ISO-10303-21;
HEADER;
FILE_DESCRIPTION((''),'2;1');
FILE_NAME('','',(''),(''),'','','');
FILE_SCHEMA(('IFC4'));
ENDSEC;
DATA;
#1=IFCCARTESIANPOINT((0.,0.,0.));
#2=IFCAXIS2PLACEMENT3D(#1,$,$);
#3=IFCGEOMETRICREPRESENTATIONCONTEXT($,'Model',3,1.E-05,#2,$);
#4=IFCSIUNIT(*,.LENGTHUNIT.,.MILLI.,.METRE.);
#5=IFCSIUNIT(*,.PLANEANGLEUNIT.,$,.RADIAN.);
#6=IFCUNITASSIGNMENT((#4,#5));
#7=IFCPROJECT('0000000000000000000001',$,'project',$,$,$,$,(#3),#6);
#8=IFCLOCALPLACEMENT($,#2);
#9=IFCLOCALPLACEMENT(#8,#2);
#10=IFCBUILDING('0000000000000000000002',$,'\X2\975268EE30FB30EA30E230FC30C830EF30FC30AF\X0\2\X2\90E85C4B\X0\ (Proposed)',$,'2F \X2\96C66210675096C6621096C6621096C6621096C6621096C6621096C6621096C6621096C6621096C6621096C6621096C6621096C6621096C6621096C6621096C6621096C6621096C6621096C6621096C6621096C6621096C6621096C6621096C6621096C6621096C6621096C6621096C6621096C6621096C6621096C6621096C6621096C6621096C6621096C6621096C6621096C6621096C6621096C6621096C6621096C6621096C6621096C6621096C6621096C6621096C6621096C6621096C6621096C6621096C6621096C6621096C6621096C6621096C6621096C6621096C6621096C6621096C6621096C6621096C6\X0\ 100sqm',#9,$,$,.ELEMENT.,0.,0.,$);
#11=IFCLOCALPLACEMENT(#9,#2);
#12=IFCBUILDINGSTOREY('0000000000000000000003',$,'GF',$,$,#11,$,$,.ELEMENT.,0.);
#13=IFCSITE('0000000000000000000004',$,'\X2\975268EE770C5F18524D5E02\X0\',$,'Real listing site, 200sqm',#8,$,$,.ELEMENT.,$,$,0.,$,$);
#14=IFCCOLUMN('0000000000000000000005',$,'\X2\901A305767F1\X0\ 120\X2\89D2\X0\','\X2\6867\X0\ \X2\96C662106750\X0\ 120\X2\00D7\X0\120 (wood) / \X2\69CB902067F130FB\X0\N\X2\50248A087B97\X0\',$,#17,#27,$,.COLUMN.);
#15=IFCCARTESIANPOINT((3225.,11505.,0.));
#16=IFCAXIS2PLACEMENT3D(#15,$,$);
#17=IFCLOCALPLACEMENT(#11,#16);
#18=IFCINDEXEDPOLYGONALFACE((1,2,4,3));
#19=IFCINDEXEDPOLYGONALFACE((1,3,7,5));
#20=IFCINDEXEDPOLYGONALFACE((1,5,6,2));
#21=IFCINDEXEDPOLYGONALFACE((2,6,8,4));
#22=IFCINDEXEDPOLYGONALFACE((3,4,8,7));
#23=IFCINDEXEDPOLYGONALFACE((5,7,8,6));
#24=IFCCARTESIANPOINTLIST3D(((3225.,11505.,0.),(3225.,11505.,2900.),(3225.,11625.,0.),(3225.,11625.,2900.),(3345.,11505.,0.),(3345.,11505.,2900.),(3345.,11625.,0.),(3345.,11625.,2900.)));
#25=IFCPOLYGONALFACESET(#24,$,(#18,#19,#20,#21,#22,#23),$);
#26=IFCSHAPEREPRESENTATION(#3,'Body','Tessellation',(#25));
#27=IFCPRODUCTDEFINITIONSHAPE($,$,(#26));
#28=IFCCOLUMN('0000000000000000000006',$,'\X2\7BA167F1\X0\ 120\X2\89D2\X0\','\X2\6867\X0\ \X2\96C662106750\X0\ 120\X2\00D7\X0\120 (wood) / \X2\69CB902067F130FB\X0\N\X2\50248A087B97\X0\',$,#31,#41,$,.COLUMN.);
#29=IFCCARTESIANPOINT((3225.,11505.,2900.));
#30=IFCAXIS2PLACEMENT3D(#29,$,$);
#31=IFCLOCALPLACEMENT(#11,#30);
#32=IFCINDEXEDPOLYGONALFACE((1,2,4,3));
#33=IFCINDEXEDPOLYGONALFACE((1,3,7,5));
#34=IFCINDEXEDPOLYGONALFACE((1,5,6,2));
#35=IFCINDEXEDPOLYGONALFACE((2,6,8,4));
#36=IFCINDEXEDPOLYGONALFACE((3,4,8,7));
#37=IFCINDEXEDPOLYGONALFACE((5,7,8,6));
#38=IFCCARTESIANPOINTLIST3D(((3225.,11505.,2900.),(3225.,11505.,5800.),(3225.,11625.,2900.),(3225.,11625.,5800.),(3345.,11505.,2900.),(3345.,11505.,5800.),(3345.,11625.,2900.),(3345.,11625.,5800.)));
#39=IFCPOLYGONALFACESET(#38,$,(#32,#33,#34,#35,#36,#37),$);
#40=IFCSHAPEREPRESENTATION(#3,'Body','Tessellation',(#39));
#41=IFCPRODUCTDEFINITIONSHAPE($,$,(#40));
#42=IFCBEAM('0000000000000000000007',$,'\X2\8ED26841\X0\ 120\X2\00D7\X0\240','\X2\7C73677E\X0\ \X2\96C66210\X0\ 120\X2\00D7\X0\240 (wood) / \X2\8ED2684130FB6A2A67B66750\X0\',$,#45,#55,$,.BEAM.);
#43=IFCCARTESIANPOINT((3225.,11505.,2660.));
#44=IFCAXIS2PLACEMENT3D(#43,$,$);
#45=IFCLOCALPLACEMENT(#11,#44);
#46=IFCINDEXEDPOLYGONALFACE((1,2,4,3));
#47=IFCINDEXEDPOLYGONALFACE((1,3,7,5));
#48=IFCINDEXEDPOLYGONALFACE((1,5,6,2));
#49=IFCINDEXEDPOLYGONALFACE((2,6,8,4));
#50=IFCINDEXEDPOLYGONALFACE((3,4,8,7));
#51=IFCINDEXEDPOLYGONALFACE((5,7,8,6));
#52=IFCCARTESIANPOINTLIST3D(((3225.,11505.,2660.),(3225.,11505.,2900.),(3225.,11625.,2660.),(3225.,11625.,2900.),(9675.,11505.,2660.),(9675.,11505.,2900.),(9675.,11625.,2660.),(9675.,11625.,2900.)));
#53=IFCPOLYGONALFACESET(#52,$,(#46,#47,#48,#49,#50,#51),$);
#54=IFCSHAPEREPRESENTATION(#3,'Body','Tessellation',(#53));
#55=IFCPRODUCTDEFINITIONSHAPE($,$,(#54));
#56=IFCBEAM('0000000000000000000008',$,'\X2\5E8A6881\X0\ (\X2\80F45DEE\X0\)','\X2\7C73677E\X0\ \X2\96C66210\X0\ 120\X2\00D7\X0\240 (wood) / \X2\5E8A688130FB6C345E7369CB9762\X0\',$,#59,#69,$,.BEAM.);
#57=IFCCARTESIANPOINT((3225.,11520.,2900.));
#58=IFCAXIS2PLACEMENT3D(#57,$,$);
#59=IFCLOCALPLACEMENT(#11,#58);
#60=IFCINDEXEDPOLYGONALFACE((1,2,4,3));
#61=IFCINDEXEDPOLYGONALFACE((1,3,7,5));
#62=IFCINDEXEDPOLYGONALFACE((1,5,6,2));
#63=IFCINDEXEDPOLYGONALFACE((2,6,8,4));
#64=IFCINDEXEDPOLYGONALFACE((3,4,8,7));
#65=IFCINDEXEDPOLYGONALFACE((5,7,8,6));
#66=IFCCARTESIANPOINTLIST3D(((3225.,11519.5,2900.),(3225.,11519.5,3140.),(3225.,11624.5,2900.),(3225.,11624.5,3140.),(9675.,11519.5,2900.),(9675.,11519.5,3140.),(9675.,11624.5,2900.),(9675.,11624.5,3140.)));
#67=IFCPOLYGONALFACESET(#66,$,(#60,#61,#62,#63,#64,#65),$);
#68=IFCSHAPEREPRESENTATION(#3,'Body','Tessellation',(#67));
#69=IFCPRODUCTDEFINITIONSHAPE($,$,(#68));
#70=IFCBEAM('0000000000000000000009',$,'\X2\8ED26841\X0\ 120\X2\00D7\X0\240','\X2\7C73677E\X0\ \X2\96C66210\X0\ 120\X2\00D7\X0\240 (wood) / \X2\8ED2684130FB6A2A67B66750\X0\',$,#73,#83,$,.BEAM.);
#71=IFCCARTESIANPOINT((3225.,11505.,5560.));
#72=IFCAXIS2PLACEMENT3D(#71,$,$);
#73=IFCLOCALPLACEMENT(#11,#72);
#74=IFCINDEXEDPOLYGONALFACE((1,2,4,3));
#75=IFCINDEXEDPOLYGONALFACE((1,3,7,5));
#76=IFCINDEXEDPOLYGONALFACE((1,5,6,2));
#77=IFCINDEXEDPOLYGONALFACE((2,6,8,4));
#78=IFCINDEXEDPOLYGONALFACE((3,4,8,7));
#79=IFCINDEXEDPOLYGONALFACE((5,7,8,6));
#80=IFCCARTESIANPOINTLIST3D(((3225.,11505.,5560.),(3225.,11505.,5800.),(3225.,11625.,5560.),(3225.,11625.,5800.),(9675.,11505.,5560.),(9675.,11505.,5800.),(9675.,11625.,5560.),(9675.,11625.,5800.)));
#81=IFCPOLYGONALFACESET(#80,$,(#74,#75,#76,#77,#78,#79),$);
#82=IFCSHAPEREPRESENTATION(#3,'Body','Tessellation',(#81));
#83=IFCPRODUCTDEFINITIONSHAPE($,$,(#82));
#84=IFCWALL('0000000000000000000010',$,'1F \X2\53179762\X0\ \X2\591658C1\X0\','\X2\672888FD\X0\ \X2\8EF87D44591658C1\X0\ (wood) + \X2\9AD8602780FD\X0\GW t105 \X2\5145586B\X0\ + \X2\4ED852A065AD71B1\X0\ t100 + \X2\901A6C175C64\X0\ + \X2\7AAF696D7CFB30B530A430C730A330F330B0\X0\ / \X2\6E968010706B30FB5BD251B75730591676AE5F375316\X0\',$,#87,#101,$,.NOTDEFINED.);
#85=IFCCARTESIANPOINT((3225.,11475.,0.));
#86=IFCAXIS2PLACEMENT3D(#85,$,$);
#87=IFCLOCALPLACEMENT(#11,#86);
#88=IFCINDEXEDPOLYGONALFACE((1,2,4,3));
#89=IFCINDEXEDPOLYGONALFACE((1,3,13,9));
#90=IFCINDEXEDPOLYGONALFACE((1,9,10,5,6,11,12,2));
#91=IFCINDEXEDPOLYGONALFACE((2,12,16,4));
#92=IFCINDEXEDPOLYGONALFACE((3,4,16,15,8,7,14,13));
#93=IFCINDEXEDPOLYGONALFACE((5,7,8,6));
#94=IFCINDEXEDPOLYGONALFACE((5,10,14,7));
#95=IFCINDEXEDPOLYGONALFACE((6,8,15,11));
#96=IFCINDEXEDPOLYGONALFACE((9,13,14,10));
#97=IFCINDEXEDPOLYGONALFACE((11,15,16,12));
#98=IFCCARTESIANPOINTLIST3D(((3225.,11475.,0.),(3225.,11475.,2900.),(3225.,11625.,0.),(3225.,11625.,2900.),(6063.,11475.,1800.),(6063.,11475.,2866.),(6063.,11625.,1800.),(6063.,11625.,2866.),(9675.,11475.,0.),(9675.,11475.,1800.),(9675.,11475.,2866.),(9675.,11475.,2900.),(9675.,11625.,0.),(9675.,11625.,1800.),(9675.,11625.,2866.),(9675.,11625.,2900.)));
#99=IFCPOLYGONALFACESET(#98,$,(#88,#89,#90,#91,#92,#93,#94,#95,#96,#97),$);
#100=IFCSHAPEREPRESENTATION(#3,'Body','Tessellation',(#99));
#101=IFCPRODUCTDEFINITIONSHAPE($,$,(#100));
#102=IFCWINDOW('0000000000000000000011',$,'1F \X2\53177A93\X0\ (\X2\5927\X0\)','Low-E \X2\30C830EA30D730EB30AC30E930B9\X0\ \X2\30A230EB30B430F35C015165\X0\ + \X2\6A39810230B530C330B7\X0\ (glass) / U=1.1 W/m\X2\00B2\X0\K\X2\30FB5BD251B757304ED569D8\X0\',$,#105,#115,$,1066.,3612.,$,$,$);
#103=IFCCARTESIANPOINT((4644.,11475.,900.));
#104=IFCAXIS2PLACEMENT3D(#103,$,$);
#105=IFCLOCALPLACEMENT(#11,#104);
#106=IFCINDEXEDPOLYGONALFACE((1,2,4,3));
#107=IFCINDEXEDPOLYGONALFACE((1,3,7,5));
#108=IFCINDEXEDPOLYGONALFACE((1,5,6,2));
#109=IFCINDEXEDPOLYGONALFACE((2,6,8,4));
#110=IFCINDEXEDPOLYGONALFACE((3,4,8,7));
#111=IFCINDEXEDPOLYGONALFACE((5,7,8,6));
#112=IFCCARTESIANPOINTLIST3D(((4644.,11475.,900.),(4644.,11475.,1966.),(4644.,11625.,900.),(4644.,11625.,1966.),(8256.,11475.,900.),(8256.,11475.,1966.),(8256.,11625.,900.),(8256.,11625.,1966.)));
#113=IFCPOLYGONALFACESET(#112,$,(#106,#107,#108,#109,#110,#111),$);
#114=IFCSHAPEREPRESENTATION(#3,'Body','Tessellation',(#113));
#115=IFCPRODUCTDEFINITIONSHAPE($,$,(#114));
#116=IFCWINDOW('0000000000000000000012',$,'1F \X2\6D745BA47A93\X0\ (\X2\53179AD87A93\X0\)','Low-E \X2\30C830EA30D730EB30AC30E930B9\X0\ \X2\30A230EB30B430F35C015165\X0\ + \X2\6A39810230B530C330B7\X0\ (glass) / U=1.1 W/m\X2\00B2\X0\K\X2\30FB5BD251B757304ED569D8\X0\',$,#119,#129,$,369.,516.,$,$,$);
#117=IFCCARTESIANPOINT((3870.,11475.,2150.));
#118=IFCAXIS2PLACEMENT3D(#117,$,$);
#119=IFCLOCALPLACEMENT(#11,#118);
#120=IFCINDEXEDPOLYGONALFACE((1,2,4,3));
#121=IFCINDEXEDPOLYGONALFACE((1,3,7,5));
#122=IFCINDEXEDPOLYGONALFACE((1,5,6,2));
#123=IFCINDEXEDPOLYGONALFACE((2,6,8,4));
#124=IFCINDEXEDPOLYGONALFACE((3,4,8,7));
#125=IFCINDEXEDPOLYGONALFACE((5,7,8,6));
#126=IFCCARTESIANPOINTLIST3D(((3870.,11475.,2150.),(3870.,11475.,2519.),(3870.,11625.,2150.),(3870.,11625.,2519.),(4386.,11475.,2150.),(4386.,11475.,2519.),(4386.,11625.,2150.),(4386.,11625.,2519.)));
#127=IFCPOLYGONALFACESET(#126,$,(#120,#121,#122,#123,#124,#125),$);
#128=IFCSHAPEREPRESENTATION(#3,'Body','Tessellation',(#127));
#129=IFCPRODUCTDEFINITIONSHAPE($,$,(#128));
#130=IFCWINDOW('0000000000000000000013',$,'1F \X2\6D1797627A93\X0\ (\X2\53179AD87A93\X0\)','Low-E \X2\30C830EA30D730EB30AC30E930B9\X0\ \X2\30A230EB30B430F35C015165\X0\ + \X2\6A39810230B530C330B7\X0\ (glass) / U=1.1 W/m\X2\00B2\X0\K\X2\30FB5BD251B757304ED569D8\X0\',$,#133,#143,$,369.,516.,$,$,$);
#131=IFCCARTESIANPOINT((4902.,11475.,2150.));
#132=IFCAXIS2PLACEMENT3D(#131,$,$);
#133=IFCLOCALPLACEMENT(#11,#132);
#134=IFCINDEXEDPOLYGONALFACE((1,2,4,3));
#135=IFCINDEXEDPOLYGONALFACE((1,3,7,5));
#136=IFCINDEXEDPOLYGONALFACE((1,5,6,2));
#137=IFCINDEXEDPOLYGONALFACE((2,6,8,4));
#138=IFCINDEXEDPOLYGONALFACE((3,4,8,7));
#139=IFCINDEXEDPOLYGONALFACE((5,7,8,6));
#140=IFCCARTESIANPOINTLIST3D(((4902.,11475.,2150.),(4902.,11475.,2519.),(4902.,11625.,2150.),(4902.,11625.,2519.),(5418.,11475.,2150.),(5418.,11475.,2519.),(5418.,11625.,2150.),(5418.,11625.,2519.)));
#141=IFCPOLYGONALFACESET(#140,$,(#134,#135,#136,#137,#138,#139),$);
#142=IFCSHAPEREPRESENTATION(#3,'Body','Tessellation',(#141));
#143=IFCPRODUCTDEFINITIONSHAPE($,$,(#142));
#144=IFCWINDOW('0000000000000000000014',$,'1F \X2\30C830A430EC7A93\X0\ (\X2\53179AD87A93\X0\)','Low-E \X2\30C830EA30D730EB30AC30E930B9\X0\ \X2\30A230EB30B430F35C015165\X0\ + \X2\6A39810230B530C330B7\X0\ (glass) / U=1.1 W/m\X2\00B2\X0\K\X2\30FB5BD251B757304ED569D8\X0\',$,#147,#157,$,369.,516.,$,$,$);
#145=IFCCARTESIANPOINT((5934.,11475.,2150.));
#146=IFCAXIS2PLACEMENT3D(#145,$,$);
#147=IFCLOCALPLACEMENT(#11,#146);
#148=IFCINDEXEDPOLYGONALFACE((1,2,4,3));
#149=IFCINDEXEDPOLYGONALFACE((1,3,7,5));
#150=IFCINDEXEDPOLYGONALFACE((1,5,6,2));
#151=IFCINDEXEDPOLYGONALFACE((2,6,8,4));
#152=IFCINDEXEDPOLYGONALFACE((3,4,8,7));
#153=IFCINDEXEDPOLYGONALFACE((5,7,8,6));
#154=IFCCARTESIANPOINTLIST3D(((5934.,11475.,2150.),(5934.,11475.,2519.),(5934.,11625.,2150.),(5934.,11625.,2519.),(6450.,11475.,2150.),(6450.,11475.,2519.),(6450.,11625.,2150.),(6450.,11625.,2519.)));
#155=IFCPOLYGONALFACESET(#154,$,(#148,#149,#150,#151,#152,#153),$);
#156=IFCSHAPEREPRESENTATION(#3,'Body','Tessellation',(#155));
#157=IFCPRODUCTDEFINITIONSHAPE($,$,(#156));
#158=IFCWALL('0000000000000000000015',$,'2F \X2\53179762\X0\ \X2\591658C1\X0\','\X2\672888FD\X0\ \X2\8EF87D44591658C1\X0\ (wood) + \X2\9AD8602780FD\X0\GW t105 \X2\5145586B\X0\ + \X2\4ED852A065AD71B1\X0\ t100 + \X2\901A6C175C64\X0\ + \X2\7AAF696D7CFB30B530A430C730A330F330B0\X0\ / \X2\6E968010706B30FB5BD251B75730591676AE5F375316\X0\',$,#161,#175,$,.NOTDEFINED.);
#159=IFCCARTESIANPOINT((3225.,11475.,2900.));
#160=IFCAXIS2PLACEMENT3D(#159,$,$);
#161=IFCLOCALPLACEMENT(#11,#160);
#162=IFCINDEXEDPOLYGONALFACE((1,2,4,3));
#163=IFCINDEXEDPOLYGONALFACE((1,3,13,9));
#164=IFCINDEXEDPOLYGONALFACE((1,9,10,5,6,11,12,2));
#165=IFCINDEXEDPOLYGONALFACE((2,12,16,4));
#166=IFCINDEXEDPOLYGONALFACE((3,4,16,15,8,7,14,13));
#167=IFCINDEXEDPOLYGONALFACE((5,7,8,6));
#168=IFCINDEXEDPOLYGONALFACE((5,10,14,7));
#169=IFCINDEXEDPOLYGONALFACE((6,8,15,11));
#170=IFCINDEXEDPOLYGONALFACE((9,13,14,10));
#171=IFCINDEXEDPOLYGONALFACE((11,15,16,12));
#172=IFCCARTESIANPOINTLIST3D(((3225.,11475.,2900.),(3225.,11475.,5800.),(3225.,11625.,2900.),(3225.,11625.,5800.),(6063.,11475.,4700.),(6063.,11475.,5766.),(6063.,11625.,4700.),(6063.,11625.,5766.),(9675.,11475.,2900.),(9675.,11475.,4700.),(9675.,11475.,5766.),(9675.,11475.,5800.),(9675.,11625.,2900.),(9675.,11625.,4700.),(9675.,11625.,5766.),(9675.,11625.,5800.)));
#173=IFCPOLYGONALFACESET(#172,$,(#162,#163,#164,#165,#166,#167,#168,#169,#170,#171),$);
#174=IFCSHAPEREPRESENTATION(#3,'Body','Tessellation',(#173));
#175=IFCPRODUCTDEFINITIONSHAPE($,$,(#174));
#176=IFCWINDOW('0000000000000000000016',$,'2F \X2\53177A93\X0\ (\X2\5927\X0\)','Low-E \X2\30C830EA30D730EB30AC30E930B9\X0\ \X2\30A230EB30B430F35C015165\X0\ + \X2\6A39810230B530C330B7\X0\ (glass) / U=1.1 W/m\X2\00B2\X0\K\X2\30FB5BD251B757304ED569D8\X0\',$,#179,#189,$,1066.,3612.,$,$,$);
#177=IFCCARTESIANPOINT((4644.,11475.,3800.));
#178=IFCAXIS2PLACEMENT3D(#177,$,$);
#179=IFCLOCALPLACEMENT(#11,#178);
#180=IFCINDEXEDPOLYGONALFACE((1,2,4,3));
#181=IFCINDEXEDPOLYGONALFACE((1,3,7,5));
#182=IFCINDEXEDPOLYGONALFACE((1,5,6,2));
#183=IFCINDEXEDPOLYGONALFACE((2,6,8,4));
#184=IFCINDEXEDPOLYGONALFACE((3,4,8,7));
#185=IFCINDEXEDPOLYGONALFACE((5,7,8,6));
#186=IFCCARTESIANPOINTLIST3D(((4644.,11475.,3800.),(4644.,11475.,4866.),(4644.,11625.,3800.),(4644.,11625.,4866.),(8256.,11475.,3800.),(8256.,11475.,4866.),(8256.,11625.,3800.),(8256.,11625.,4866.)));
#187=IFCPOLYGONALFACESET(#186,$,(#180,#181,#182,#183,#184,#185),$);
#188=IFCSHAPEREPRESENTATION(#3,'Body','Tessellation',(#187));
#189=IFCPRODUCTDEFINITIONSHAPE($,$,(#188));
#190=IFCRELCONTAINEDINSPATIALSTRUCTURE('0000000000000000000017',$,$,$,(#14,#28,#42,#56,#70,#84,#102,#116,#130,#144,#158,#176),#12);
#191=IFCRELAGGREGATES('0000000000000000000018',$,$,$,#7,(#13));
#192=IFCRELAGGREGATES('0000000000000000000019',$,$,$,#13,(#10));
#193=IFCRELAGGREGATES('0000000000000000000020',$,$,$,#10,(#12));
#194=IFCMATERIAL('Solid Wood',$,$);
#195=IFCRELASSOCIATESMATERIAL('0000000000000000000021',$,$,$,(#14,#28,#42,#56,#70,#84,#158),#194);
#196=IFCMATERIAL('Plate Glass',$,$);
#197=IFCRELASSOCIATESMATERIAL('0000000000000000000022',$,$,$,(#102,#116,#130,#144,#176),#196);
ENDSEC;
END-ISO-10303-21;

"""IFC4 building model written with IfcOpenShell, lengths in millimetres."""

from ifc_helpers import new_model, si_unit, frame, frame_2d, origin, place, context, project, spatial, rectangle, extrude, material, element, fill, save


model = new_model("IFC4")

# Units and contexts
model_context = context("Model", 3, precision=1e-05, world=origin())
ifc_project = project(units=[si_unit("LENGTHUNIT", "METRE", prefix="MILLI"), si_unit("PLANEANGLEUNIT", "RADIAN")], contexts=[model_context])

# Site, building, storey
site_placement = place(None, origin())
site = spatial("IfcSite", under=ifc_project, at=site_placement, Name="青森県弘前市", ObjectType="Real listing site, 200sqm", CompositionType="ELEMENT", RefElevation=0.0)
building_placement = place(site_placement, origin())
building = spatial("IfcBuilding", under=site, at=building_placement, Name="青森・リモートワーク2部屋 (Proposed)", ObjectType="2F 集成材集成集成集成集成集成集成集成集成集成集成集成集成集成集成集成集成集成集成集成集成集成集成集成集成集成集成集成集成集成集成集成集成集成集成集成集成集成集成集成集成集成集成集成集成集成集成集成集成集成集成集成集成集成集成集成集成集成集成集 100sqm", CompositionType="ELEMENT", ElevationOfRefHeight=0.0, ElevationOfTerrain=0.0)
storey_placement = place(building_placement, origin())
storey = spatial("IfcBuildingStorey", under=building, at=storey_placement, Name="GF", CompositionType="ELEMENT", Elevation=0.0)

# Columns
ifc_material_1 = material(Name="Solid Wood")
column_1_placement = place(storey_placement, frame((3225.0, 11505.0, 0.0)))
element("IfcColumn", 1, at=column_1_placement, inside=storey, material=ifc_material_1, Name="通し柱 120角", Description="桧 集成材 120×120 (wood) / 構造柱・N値計算", PredefinedType="COLUMN", context=model_context, shape_type="SweptSolid", body=[
    extrude(rectangle(XDim=120.0, YDim=120.0, at=frame_2d((60.0, 60.0))), frame((3225.0, 11505.0, 0.0)), (0.0, 0.0, 1.0), 2900.0),
])
column_2_placement = place(storey_placement, frame((3225.0, 11505.0, 2900.0)))
element("IfcColumn", 2, at=column_2_placement, inside=storey, material=ifc_material_1, Name="管柱 120角", Description="桧 集成材 120×120 (wood) / 構造柱・N値計算", PredefinedType="COLUMN", context=model_context, shape_type="SweptSolid", body=[
    extrude(rectangle(XDim=120.0, YDim=120.0, at=frame_2d((60.0, 60.0))), frame((3225.0, 11505.0, 2900.0)), (0.0, 0.0, 1.0), 2900.0),
])

# Beams
beam_1_placement = place(storey_placement, frame((3225.0, 11505.0, 2660.0)))
element("IfcBeam", 3, at=beam_1_placement, inside=storey, material=ifc_material_1, Name="軒桁 120×240", Description="米松 集成 120×240 (wood) / 軒桁・横架材", PredefinedType="BEAM", context=model_context, shape_type="SweptSolid", body=[
    extrude(rectangle(XDim=6450.0, YDim=120.0, at=frame_2d((3225.0, 60.0))), frame((3225.0, 11505.0, 2660.0)), (0.0, 0.0, 1.0), 240.0),
])
beam_2_placement = place(storey_placement, frame((3225.0, 11520.0, 2900.0)))
element("IfcBeam", 4, at=beam_2_placement, inside=storey, material=ifc_material_1, Name="床梁 (胴差)", Description="米松 集成 120×240 (wood) / 床梁・水平構面", PredefinedType="BEAM", context=model_context, shape_type="SweptSolid", body=[
    extrude(rectangle(XDim=6450.0, YDim=105.0, at=frame_2d((3225.0, 52.0))), frame((3225.0, 11520.0, 2900.0)), (0.0, 0.0, 1.0), 240.0),
])
beam_3_placement = place(storey_placement, frame((3225.0, 11505.0, 5560.0)))
element("IfcBeam", 5, at=beam_3_placement, inside=storey, material=ifc_material_1, Name="軒桁 120×240", Description="米松 集成 120×240 (wood) / 軒桁・横架材", PredefinedType="BEAM", context=model_context, shape_type="SweptSolid", body=[
    extrude(rectangle(XDim=6450.0, YDim=120.0, at=frame_2d((3225.0, 60.0))), frame((3225.0, 11505.0, 5560.0)), (0.0, 0.0, 1.0), 240.0),
])

# Wall, openings, windows
wall_1_placement = place(storey_placement, frame((3225.0, 11475.0, 0.0)))
wall_1 = element("IfcWall", 6, at=wall_1_placement, inside=storey, material=ifc_material_1, Name="1F 北面 外壁", Description="木製 軸組外壁 (wood) + 高性能GW t105 充填 + 付加断熱 t100 + 通気層 + 窯業系サイディング / 準耐火・寒冷地外皮強化", PredefinedType="NOTDEFINED", context=model_context, shape_type="SweptSolid", body=[
    extrude(rectangle(XDim=6450.0, YDim=150.0, at=frame_2d((3225.0, 75.0))), frame((3225.0, 11475.0, 0.0)), (0.0, 0.0, 1.0), 2900.0),
])
opening_1_placement = place(storey_placement, frame((4644.0, 11475.0, 900.0)))
opening_1 = element("IfcOpeningElement", 7, at=opening_1_placement, cuts=wall_1, PredefinedType="NOTDEFINED", context=model_context, shape_type="SweptSolid", body=[
    extrude(rectangle(XDim=3612.0, YDim=150.0, at=frame_2d((1806.0, 75.0))), frame((4644.0, 11475.0, 900.0)), (0.0, 0.0, 1.0), 1066.0),
])
opening_2_placement = place(storey_placement, frame((3870.0, 11475.0, 2150.0)))
opening_2 = element("IfcOpeningElement", 8, at=opening_2_placement, cuts=wall_1, PredefinedType="NOTDEFINED", context=model_context, shape_type="SweptSolid", body=[
    extrude(rectangle(XDim=516.0, YDim=150.0, at=frame_2d((258.0, 75.0))), frame((3870.0, 11475.0, 2150.0)), (0.0, 0.0, 1.0), 369.0),
])
opening_3_placement = place(storey_placement, frame((4902.0, 11475.0, 2150.0)))
opening_3 = element("IfcOpeningElement", 9, at=opening_3_placement, cuts=wall_1, PredefinedType="NOTDEFINED", context=model_context, shape_type="SweptSolid", body=[
    extrude(rectangle(XDim=516.0, YDim=150.0, at=frame_2d((258.0, 75.0))), frame((4902.0, 11475.0, 2150.0)), (0.0, 0.0, 1.0), 369.0),
])
opening_4_placement = place(storey_placement, frame((5934.0, 11475.0, 2150.0)))
opening_4 = element("IfcOpeningElement", 10, at=opening_4_placement, cuts=wall_1, PredefinedType="NOTDEFINED", context=model_context, shape_type="SweptSolid", body=[
    extrude(rectangle(XDim=516.0, YDim=150.0, at=frame_2d((258.0, 75.0))), frame((5934.0, 11475.0, 2150.0)), (0.0, 0.0, 1.0), 369.0),
])
ifc_material_2 = material(Name="Plate Glass")
window_1_placement = place(storey_placement, frame((4644.0, 11475.0, 900.0)))
window_1 = element("IfcWindow", 11, at=window_1_placement, inside=storey, material=ifc_material_2, Name="1F 北窓 (大)", Description="Low-E トリプルガラス アルゴン封入 + 樹脂サッシ (glass) / U=1.1 W/m²K・寒冷地仕様", OverallHeight=1066.0, OverallWidth=3612.0, context=model_context, shape_type="SweptSolid", body=[
    extrude(rectangle(XDim=3612.0, YDim=150.0, at=frame_2d((1806.0, 75.0))), frame((4644.0, 11475.0, 900.0)), (0.0, 0.0, 1.0), 1066.0),
])
fill(opening_1, window_1)
window_2_placement = place(storey_placement, frame((3870.0, 11475.0, 2150.0)))
window_2 = element("IfcWindow", 12, at=window_2_placement, inside=storey, material=ifc_material_2, Name="1F 浴室窓 (北高窓)", Description="Low-E トリプルガラス アルゴン封入 + 樹脂サッシ (glass) / U=1.1 W/m²K・寒冷地仕様", OverallHeight=369.0, OverallWidth=516.0, context=model_context, shape_type="SweptSolid", body=[
    extrude(rectangle(XDim=516.0, YDim=150.0, at=frame_2d((258.0, 75.0))), frame((3870.0, 11475.0, 2150.0)), (0.0, 0.0, 1.0), 369.0),
])
fill(opening_2, window_2)
window_3_placement = place(storey_placement, frame((4902.0, 11475.0, 2150.0)))
window_3 = element("IfcWindow", 13, at=window_3_placement, inside=storey, material=ifc_material_2, Name="1F 洗面窓 (北高窓)", Description="Low-E トリプルガラス アルゴン封入 + 樹脂サッシ (glass) / U=1.1 W/m²K・寒冷地仕様", OverallHeight=369.0, OverallWidth=516.0, context=model_context, shape_type="SweptSolid", body=[
    extrude(rectangle(XDim=516.0, YDim=150.0, at=frame_2d((258.0, 75.0))), frame((4902.0, 11475.0, 2150.0)), (0.0, 0.0, 1.0), 369.0),
])
fill(opening_3, window_3)
window_4_placement = place(storey_placement, frame((5934.0, 11475.0, 2150.0)))
window_4 = element("IfcWindow", 14, at=window_4_placement, inside=storey, material=ifc_material_2, Name="1F トイレ窓 (北高窓)", Description="Low-E トリプルガラス アルゴン封入 + 樹脂サッシ (glass) / U=1.1 W/m²K・寒冷地仕様", OverallHeight=369.0, OverallWidth=516.0, context=model_context, shape_type="SweptSolid", body=[
    extrude(rectangle(XDim=516.0, YDim=150.0, at=frame_2d((258.0, 75.0))), frame((5934.0, 11475.0, 2150.0)), (0.0, 0.0, 1.0), 369.0),
])
fill(opening_4, window_4)

# Wall, opening, window
wall_2_placement = place(storey_placement, frame((3225.0, 11475.0, 2900.0)))
wall_2 = element("IfcWall", 15, at=wall_2_placement, inside=storey, material=ifc_material_1, Name="2F 北面 外壁", Description="木製 軸組外壁 (wood) + 高性能GW t105 充填 + 付加断熱 t100 + 通気層 + 窯業系サイディング / 準耐火・寒冷地外皮強化", PredefinedType="NOTDEFINED", context=model_context, shape_type="SweptSolid", body=[
    extrude(rectangle(XDim=6450.0, YDim=150.0, at=frame_2d((3225.0, 75.0))), frame((3225.0, 11475.0, 2900.0)), (0.0, 0.0, 1.0), 2900.0),
])
opening_5_placement = place(storey_placement, frame((4644.0, 11475.0, 3800.0)))
opening_5 = element("IfcOpeningElement", 16, at=opening_5_placement, cuts=wall_2, PredefinedType="NOTDEFINED", context=model_context, shape_type="SweptSolid", body=[
    extrude(rectangle(XDim=3612.0, YDim=150.0, at=frame_2d((1806.0, 75.0))), frame((4644.0, 11475.0, 3800.0)), (0.0, 0.0, 1.0), 1066.0),
])
window_5_placement = place(storey_placement, frame((4644.0, 11475.0, 3800.0)))
window_5 = element("IfcWindow", 17, at=window_5_placement, inside=storey, material=ifc_material_2, Name="2F 北窓 (大)", Description="Low-E トリプルガラス アルゴン封入 + 樹脂サッシ (glass) / U=1.1 W/m²K・寒冷地仕様", OverallHeight=1066.0, OverallWidth=3612.0, context=model_context, shape_type="SweptSolid", body=[
    extrude(rectangle(XDim=3612.0, YDim=150.0, at=frame_2d((1806.0, 75.0))), frame((4644.0, 11475.0, 3800.0)), (0.0, 0.0, 1.0), 1066.0),
])
fill(opening_5, window_5)

save(model, "model.ifc")
